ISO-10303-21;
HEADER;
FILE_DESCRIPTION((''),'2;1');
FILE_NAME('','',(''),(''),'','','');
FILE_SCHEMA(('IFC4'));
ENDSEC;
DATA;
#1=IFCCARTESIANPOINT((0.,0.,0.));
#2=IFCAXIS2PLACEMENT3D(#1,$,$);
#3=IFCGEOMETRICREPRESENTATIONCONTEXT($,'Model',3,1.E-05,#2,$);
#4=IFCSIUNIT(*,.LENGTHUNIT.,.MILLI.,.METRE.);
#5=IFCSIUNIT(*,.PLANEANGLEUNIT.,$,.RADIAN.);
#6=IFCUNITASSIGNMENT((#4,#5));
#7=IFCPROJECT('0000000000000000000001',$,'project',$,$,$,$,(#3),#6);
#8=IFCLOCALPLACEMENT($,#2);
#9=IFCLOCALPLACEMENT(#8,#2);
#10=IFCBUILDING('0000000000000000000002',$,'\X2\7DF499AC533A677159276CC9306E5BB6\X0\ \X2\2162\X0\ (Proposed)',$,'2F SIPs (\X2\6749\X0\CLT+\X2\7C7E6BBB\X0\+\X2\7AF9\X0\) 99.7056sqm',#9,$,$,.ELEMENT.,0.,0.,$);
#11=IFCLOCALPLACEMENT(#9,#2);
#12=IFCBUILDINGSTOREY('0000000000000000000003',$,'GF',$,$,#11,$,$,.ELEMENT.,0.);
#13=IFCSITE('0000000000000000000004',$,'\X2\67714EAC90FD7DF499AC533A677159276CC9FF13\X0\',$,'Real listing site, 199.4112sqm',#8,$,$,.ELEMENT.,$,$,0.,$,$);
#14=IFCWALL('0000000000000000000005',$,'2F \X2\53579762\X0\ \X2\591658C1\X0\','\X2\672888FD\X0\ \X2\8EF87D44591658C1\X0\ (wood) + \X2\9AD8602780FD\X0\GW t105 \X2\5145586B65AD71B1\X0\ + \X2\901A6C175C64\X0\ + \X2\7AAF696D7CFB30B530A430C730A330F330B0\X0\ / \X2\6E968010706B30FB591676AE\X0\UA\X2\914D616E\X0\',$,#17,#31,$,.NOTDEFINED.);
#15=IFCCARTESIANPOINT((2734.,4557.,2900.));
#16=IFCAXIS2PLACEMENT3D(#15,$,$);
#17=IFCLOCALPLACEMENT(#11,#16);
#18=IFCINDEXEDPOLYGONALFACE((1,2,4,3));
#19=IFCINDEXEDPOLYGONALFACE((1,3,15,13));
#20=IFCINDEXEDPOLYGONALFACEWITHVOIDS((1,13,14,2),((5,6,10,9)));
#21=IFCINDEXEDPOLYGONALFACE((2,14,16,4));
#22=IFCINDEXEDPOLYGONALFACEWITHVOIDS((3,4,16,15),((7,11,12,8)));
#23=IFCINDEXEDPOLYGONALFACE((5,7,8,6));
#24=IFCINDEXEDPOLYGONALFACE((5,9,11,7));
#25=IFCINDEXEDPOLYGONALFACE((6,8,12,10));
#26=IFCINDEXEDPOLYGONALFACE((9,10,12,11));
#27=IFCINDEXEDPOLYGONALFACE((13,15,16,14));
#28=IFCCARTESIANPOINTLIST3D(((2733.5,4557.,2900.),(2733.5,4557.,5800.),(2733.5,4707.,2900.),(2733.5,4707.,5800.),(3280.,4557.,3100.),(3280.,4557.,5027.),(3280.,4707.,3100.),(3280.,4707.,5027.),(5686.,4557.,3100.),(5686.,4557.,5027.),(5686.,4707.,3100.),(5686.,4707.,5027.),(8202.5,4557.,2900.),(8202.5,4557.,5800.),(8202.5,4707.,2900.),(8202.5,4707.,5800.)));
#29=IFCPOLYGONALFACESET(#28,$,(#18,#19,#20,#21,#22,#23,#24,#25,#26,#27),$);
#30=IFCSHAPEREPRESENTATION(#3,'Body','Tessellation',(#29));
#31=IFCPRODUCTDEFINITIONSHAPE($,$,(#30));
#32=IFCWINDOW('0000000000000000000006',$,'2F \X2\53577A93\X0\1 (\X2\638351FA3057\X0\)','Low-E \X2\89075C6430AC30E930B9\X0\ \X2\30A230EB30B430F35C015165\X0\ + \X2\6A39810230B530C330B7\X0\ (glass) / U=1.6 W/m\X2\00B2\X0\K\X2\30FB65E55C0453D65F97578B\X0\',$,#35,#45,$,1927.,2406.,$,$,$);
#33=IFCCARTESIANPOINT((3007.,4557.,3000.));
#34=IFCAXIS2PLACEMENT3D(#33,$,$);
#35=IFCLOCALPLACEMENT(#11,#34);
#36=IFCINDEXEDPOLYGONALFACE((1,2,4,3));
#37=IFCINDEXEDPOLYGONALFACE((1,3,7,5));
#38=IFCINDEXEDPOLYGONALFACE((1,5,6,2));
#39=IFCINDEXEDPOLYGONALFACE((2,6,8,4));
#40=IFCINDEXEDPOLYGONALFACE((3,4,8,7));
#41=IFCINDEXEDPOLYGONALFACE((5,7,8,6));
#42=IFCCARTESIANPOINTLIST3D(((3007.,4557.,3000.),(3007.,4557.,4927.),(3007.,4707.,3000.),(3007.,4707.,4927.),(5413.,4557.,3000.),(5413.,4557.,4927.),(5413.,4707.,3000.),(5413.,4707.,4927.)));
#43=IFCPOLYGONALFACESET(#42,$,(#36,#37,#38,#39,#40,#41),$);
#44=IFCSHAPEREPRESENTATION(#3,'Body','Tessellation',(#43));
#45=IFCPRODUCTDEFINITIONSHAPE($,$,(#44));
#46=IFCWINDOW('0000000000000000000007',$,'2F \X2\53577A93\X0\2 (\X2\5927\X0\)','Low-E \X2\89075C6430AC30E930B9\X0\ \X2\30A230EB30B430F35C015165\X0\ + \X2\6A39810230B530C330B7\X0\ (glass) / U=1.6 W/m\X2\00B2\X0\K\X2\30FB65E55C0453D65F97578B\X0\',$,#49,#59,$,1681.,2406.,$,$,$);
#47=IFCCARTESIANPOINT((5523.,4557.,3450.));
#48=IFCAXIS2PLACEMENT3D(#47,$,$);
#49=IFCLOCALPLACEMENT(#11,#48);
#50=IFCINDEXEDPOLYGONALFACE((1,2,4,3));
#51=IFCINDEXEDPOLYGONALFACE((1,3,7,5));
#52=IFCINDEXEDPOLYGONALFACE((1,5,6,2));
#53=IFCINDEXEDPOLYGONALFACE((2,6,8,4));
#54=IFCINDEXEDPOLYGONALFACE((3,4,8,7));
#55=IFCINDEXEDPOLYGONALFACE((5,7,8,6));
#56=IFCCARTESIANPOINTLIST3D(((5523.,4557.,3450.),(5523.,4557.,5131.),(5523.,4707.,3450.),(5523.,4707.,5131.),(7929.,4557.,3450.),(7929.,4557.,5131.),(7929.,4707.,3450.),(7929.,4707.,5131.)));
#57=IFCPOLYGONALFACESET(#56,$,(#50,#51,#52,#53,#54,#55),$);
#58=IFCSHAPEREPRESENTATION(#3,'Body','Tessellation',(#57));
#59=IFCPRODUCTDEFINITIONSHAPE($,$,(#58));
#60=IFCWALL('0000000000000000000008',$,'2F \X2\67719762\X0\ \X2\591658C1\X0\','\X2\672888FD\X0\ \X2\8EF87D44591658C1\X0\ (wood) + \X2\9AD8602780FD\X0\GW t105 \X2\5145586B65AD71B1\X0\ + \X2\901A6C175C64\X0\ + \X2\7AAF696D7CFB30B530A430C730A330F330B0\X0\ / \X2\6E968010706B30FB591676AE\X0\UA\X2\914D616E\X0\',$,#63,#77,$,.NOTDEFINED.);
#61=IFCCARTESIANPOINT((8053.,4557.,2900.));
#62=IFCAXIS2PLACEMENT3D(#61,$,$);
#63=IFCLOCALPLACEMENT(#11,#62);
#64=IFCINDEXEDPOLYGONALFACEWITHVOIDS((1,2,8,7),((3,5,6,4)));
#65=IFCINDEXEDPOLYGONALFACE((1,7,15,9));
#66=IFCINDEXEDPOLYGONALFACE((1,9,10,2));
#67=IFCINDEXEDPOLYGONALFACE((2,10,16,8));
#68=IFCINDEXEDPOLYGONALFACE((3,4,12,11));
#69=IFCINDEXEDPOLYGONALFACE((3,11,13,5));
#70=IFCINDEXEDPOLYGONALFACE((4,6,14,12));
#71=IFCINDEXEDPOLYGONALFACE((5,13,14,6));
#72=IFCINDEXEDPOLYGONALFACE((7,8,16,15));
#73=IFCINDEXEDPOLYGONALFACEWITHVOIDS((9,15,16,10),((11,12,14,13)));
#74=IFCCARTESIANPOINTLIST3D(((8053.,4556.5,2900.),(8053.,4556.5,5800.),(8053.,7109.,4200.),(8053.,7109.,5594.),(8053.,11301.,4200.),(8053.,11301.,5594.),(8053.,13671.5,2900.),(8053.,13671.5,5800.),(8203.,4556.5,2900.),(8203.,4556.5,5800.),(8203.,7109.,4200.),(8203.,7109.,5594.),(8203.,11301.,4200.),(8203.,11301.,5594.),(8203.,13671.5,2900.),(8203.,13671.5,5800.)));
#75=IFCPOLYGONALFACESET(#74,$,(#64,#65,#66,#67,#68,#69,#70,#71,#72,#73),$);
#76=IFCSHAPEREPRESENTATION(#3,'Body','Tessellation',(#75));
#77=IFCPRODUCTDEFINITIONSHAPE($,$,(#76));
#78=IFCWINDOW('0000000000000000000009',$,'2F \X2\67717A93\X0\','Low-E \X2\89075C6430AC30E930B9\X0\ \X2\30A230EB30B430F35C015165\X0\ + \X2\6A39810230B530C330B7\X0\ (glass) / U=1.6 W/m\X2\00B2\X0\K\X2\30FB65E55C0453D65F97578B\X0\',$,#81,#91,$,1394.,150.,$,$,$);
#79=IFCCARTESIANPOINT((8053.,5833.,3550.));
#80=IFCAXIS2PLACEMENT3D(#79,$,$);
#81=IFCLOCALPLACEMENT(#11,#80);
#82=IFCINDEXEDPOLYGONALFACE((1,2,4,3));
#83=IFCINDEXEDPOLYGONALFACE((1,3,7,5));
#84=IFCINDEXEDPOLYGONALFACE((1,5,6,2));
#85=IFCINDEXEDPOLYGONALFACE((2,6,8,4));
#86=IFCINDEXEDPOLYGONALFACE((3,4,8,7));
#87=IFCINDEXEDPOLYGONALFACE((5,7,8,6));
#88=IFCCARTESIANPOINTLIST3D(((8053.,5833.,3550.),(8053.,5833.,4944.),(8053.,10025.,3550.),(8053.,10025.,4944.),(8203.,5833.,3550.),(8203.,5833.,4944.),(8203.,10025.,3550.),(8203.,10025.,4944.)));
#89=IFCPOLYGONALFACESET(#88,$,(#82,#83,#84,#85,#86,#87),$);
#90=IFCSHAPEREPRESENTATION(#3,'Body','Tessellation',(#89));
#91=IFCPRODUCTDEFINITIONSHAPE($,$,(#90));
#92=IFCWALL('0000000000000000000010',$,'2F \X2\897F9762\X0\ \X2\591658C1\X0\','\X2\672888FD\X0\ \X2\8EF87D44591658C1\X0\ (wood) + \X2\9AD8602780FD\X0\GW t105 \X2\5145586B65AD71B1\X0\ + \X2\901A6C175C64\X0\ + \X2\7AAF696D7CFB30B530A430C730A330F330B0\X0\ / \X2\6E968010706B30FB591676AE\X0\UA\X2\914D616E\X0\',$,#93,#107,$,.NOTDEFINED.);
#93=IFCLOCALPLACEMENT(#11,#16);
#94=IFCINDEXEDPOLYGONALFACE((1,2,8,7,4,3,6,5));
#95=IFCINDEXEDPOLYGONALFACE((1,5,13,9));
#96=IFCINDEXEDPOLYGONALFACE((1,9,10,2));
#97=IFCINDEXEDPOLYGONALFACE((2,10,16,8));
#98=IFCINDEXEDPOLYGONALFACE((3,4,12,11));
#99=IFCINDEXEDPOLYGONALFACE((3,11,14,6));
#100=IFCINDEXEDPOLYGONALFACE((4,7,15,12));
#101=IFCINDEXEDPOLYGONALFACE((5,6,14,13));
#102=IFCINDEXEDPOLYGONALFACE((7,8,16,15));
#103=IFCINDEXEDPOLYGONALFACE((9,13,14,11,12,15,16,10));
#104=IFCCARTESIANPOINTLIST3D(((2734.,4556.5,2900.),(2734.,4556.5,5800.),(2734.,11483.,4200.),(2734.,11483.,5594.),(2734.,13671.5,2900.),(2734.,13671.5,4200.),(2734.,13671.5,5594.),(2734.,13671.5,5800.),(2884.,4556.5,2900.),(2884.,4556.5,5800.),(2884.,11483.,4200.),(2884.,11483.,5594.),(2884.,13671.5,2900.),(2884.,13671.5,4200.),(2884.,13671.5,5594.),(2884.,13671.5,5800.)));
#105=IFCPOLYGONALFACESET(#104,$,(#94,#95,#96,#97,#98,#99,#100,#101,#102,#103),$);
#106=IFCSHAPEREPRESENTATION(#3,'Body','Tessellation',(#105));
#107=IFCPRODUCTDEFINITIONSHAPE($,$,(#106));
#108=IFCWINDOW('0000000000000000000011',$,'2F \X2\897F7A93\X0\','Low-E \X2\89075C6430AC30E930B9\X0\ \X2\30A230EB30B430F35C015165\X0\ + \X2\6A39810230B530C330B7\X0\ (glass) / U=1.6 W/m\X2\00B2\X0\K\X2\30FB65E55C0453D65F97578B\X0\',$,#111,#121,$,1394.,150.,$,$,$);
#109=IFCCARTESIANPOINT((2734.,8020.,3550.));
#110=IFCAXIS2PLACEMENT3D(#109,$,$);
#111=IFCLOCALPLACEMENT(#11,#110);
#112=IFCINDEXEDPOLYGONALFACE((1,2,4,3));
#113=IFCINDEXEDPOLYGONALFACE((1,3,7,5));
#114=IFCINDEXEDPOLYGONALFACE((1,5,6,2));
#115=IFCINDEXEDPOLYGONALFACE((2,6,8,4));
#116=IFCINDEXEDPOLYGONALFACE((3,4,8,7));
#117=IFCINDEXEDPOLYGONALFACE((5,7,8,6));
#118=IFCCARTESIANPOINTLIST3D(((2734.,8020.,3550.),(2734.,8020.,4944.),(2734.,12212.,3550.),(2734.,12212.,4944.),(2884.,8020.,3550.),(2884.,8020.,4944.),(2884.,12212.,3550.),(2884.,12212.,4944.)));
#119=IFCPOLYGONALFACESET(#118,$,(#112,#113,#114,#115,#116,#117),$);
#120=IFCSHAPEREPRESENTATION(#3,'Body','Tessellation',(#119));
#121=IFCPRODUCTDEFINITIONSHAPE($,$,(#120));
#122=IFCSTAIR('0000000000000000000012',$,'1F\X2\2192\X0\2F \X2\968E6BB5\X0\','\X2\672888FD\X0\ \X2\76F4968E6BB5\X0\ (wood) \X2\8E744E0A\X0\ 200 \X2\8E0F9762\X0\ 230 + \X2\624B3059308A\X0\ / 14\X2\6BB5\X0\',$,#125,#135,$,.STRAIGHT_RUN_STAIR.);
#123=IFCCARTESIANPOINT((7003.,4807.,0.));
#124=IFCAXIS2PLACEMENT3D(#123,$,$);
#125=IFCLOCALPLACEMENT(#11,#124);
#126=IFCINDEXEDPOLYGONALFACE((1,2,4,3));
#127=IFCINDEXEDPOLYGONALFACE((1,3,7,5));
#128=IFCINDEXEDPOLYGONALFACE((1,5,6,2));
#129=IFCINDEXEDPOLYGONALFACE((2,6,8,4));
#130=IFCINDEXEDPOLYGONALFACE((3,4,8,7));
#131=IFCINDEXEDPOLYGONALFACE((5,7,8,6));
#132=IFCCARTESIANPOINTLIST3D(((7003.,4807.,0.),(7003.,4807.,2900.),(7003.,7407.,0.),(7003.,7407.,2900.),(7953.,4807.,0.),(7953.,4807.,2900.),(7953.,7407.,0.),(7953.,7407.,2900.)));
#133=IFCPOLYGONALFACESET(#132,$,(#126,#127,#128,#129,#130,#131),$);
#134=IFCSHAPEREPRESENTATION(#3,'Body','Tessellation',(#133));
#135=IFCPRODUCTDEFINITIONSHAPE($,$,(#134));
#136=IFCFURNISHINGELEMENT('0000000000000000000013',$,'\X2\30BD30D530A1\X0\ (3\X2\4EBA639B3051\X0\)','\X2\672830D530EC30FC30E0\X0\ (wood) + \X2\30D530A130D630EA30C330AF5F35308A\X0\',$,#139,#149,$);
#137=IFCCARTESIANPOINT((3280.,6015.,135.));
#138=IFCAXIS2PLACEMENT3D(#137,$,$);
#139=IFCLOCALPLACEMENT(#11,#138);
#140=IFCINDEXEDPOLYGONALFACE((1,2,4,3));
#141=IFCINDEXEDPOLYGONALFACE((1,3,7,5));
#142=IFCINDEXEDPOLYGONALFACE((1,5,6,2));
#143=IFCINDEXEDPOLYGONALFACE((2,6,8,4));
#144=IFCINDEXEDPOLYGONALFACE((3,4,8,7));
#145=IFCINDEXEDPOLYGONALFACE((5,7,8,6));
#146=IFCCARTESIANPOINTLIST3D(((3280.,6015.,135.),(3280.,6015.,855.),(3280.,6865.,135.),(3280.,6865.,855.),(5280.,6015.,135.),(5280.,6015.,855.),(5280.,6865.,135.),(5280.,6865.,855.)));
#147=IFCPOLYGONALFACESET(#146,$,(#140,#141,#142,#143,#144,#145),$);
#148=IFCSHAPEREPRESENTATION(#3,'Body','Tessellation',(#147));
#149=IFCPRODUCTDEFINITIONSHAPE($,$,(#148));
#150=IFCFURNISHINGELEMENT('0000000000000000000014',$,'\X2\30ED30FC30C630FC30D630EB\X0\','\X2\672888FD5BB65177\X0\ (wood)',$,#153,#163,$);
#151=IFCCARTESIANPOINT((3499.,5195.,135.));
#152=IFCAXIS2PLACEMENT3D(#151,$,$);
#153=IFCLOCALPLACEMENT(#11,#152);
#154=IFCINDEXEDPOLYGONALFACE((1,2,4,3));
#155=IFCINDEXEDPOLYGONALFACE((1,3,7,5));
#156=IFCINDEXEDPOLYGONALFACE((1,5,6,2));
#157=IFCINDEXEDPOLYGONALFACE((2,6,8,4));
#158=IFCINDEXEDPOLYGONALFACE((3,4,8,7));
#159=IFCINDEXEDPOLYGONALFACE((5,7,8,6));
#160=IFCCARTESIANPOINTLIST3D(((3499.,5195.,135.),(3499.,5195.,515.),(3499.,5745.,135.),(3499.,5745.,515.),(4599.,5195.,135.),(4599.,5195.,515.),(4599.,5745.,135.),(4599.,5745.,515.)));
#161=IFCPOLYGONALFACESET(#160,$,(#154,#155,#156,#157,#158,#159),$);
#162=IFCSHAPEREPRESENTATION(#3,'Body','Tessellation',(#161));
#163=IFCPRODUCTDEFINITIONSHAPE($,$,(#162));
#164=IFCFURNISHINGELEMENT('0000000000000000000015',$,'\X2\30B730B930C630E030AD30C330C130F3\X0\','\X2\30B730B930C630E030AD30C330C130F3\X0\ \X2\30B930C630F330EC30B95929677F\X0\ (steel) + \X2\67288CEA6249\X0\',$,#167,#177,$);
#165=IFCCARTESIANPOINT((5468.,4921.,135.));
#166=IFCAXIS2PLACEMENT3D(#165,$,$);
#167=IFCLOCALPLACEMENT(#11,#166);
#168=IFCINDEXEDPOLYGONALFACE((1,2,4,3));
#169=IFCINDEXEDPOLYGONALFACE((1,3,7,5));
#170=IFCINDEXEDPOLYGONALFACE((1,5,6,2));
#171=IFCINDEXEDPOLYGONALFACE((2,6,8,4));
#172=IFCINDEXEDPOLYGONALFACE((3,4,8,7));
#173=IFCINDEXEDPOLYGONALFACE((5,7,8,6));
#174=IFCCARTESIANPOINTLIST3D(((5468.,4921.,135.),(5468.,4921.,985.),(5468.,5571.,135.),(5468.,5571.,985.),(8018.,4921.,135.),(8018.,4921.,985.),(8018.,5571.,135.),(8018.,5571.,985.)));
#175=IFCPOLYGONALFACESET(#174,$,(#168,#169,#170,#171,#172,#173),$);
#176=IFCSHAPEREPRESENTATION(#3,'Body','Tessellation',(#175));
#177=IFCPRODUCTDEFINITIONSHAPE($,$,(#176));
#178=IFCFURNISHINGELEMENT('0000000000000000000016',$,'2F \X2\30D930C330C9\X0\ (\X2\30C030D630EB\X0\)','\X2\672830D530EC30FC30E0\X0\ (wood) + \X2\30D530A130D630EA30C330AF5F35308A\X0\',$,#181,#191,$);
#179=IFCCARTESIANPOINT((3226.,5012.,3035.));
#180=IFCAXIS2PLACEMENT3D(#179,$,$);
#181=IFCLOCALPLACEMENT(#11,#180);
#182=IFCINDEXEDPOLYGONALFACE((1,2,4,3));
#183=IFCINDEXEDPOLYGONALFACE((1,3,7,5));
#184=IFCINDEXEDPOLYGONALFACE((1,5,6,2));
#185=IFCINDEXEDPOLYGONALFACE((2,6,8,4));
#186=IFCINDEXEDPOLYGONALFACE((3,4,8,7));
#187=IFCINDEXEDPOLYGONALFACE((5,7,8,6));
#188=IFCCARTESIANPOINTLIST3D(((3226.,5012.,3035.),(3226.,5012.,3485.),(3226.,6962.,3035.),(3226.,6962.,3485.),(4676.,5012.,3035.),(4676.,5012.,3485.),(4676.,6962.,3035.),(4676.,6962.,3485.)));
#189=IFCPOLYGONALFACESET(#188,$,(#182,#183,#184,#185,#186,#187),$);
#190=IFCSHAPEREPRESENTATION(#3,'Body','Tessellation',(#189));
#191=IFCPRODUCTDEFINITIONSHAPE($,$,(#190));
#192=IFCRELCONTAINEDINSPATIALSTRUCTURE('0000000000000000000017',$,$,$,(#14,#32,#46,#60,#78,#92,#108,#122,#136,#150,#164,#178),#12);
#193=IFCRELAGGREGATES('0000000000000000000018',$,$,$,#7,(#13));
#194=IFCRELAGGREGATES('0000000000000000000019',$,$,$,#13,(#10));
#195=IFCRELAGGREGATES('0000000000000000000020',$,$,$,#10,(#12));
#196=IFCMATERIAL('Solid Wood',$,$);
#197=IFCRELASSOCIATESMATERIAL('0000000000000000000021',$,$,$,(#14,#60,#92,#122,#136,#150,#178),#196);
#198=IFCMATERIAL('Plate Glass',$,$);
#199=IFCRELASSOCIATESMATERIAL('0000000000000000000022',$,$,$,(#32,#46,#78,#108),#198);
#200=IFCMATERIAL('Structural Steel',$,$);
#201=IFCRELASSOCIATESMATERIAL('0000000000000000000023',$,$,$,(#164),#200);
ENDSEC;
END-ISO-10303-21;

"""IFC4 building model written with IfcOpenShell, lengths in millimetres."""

from ifc_helpers import new_model, si_unit, frame, frame_2d, origin, place, context, project, spatial, rectangle, extrude, material, element, fill, save


model = new_model("IFC4")

# Units and contexts
model_context = context("Model", 3, precision=1e-05, world=origin())
ifc_project = project(units=[si_unit("LENGTHUNIT", "METRE", prefix="MILLI"), si_unit("PLANEANGLEUNIT", "RADIAN")], contexts=[model_context])

# Site, building, storey
site_placement = place(None, origin())
site = spatial("IfcSite", under=ifc_project, at=site_placement, Name="東京都練馬区東大泉３", ObjectType="Real listing site, 199.4112sqm", CompositionType="ELEMENT", RefElevation=0.0)
building_placement = place(site_placement, origin())
building = spatial("IfcBuilding", under=site, at=building_placement, Name="練馬区東大泉の家 Ⅲ (Proposed)", ObjectType="2F SIPs (杉CLT+籾殻+竹) 99.7056sqm", CompositionType="ELEMENT", ElevationOfRefHeight=0.0, ElevationOfTerrain=0.0)
storey_placement = place(building_placement, origin())
storey = spatial("IfcBuildingStorey", under=building, at=storey_placement, Name="GF", CompositionType="ELEMENT", Elevation=0.0)

# Shared definitions
ifc_material_1 = material(Name="Solid Wood")

# Shared definitions
ifc_material_2 = material(Name="Plate Glass")

# Wall, openings, windows
wall_1_placement = place(storey_placement, frame((2734.0, 4557.0, 2900.0)))
wall_1 = element("IfcWall", 1, at=wall_1_placement, inside=storey, material=ifc_material_1, Name="2F 南面 外壁", Description="木製 軸組外壁 (wood) + 高性能GW t105 充填断熱 + 通気層 + 窯業系サイディング / 準耐火・外皮UA配慮", PredefinedType="NOTDEFINED", context=model_context, shape_type="SweptSolid", body=[
    extrude(rectangle(XDim=5469.0, YDim=150.0, at=frame_2d((2734.0, 75.0))), frame((2734.0, 4557.0, 2900.0)), (0.0, 0.0, 1.0), 2900.0),
])
opening_1_placement = place(storey_placement, frame((3007.0, 4557.0, 3000.0)))
opening_1 = element("IfcOpeningElement", 2, at=opening_1_placement, cuts=wall_1, PredefinedType="NOTDEFINED", context=model_context, shape_type="SweptSolid", body=[
    extrude(rectangle(XDim=2406.0, YDim=150.0, at=frame_2d((1203.0, 75.0))), frame((3007.0, 4557.0, 3000.0)), (0.0, 0.0, 1.0), 1927.0),
])
opening_2_placement = place(storey_placement, frame((5523.0, 4557.0, 3450.0)))
opening_2 = element("IfcOpeningElement", 3, at=opening_2_placement, cuts=wall_1, PredefinedType="NOTDEFINED", context=model_context, shape_type="SweptSolid", body=[
    extrude(rectangle(XDim=2406.0, YDim=150.0, at=frame_2d((1203.0, 75.0))), frame((5523.0, 4557.0, 3450.0)), (0.0, 0.0, 1.0), 1681.0),
])
window_1_placement = place(storey_placement, frame((3007.0, 4557.0, 3000.0)))
window_1 = element("IfcWindow", 4, at=window_1_placement, inside=storey, material=ifc_material_2, Name="2F 南窓1 (掃出し)", Description="Low-E 複層ガラス アルゴン封入 + 樹脂サッシ (glass) / U=1.6 W/m²K・日射取得型", OverallHeight=1927.0, OverallWidth=2406.0, context=model_context, shape_type="SweptSolid", body=[
    extrude(rectangle(XDim=2406.0, YDim=150.0, at=frame_2d((1203.0, 75.0))), frame((3007.0, 4557.0, 3000.0)), (0.0, 0.0, 1.0), 1927.0),
])
fill(opening_1, window_1)
window_2_placement = place(storey_placement, frame((5523.0, 4557.0, 3450.0)))
window_2 = element("IfcWindow", 5, at=window_2_placement, inside=storey, material=ifc_material_2, Name="2F 南窓2 (大)", Description="Low-E 複層ガラス アルゴン封入 + 樹脂サッシ (glass) / U=1.6 W/m²K・日射取得型", OverallHeight=1681.0, OverallWidth=2406.0, context=model_context, shape_type="SweptSolid", body=[
    extrude(rectangle(XDim=2406.0, YDim=150.0, at=frame_2d((1203.0, 75.0))), frame((5523.0, 4557.0, 3450.0)), (0.0, 0.0, 1.0), 1681.0),
])
fill(opening_2, window_2)

# Walls, openings, windows
wall_2_placement = place(storey_placement, frame((8053.0, 4557.0, 2900.0)))
wall_2 = element("IfcWall", 6, at=wall_2_placement, inside=storey, material=ifc_material_1, Name="2F 東面 外壁", Description="木製 軸組外壁 (wood) + 高性能GW t105 充填断熱 + 通気層 + 窯業系サイディング / 準耐火・外皮UA配慮", PredefinedType="NOTDEFINED", context=model_context, shape_type="SweptSolid", body=[
    extrude(rectangle(XDim=150.0, YDim=9115.0, at=frame_2d((75.0, 4557.0))), frame((8053.0, 4557.0, 2900.0)), (0.0, 0.0, 1.0), 2900.0),
])
opening_3_placement = place(storey_placement, frame((8053.0, 5833.0, 3550.0)))
opening_3 = element("IfcOpeningElement", 7, at=opening_3_placement, cuts=wall_2, PredefinedType="NOTDEFINED", context=model_context, shape_type="SweptSolid", body=[
    extrude(rectangle(XDim=150.0, YDim=4192.0, at=frame_2d((75.0, 2096.0))), frame((8053.0, 5833.0, 3550.0)), (0.0, 0.0, 1.0), 1394.0),
])
window_3_placement = place(storey_placement, frame((8053.0, 5833.0, 3550.0)))
window_3 = element("IfcWindow", 8, at=window_3_placement, inside=storey, material=ifc_material_2, Name="2F 東窓", Description="Low-E 複層ガラス アルゴン封入 + 樹脂サッシ (glass) / U=1.6 W/m²K・日射取得型", OverallHeight=1394.0, OverallWidth=150.0, context=model_context, shape_type="SweptSolid", body=[
    extrude(rectangle(XDim=150.0, YDim=4192.0, at=frame_2d((75.0, 2096.0))), frame((8053.0, 5833.0, 3550.0)), (0.0, 0.0, 1.0), 1394.0),
])
fill(opening_3, window_3)
wall_3_placement = place(storey_placement, frame((2734.0, 4557.0, 2900.0)))
wall_3 = element("IfcWall", 9, at=wall_3_placement, inside=storey, material=ifc_material_1, Name="2F 西面 外壁", Description="木製 軸組外壁 (wood) + 高性能GW t105 充填断熱 + 通気層 + 窯業系サイディング / 準耐火・外皮UA配慮", PredefinedType="NOTDEFINED", context=model_context, shape_type="SweptSolid", body=[
    extrude(rectangle(XDim=150.0, YDim=9115.0, at=frame_2d((75.0, 4557.0))), frame((2734.0, 4557.0, 2900.0)), (0.0, 0.0, 1.0), 2900.0),
])
opening_4_placement = place(storey_placement, frame((2734.0, 8020.0, 3550.0)))
opening_4 = element("IfcOpeningElement", 10, at=opening_4_placement, cuts=wall_3, PredefinedType="NOTDEFINED", context=model_context, shape_type="SweptSolid", body=[
    extrude(rectangle(XDim=150.0, YDim=4192.0, at=frame_2d((75.0, 2096.0))), frame((2734.0, 8020.0, 3550.0)), (0.0, 0.0, 1.0), 1394.0),
])
window_4_placement = place(storey_placement, frame((2734.0, 8020.0, 3550.0)))
window_4 = element("IfcWindow", 11, at=window_4_placement, inside=storey, material=ifc_material_2, Name="2F 西窓", Description="Low-E 複層ガラス アルゴン封入 + 樹脂サッシ (glass) / U=1.6 W/m²K・日射取得型", OverallHeight=1394.0, OverallWidth=150.0, context=model_context, shape_type="SweptSolid", body=[
    extrude(rectangle(XDim=150.0, YDim=4192.0, at=frame_2d((75.0, 2096.0))), frame((2734.0, 8020.0, 3550.0)), (0.0, 0.0, 1.0), 1394.0),
])
fill(opening_4, window_4)

# Stair
stair_placement = place(storey_placement, frame((7003.0, 4807.0, 0.0)))
element("IfcStair", 12, at=stair_placement, inside=storey, material=ifc_material_1, Name="1F→2F 階段", Description="木製 直階段 (wood) 蹴上 200 踏面 230 + 手すり / 14段", PredefinedType="STRAIGHT_RUN_STAIR", context=model_context, shape_type="SweptSolid", body=[
    extrude(rectangle(XDim=950.0, YDim=2600.0, at=frame_2d((475.0, 1300.0))), frame((7003.0, 4807.0, 0.0)), (0.0, 0.0, 1.0), 2900.0),
])

# Shared definitions
ifc_material_3 = material(Name="Structural Steel")

# Furnishing elements
furnishing_1_placement = place(storey_placement, frame((3280.0, 6015.0, 135.0)))
element("IfcFurnishingElement", 13, at=furnishing_1_placement, inside=storey, material=ifc_material_1, Name="ソファ (3人掛け)", Description="木フレーム (wood) + ファブリック張り", context=model_context, shape_type="SweptSolid", body=[
    extrude(rectangle(XDim=2000.0, YDim=850.0, at=frame_2d((1000.0, 425.0))), frame((3280.0, 6015.0, 135.0)), (0.0, 0.0, 1.0), 720.0),
])
furnishing_2_placement = place(storey_placement, frame((3499.0, 5195.0, 135.0)))
element("IfcFurnishingElement", 14, at=furnishing_2_placement, inside=storey, material=ifc_material_1, Name="ローテーブル", Description="木製家具 (wood)", context=model_context, shape_type="SweptSolid", body=[
    extrude(rectangle(XDim=1100.0, YDim=550.0, at=frame_2d((550.0, 275.0))), frame((3499.0, 5195.0, 135.0)), (0.0, 0.0, 1.0), 380.0),
])
furnishing_3_placement = place(storey_placement, frame((5468.0, 4921.0, 135.0)))
element("IfcFurnishingElement", 15, at=furnishing_3_placement, inside=storey, material=ifc_material_3, Name="システムキッチン", Description="システムキッチン ステンレス天板 (steel) + 木質扉", context=model_context, shape_type="SweptSolid", body=[
    extrude(rectangle(XDim=2550.0, YDim=650.0, at=frame_2d((1275.0, 325.0))), frame((5468.0, 4921.0, 135.0)), (0.0, 0.0, 1.0), 850.0),
])
furnishing_4_placement = place(storey_placement, frame((3226.0, 5012.0, 3035.0)))
element("IfcFurnishingElement", 16, at=furnishing_4_placement, inside=storey, material=ifc_material_1, Name="2F ベッド (ダブル)", Description="木フレーム (wood) + ファブリック張り", context=model_context, shape_type="SweptSolid", body=[
    extrude(rectangle(XDim=1450.0, YDim=1950.0, at=frame_2d((725.0, 975.0))), frame((3226.0, 5012.0, 3035.0)), (0.0, 0.0, 1.0), 450.0),
])

save(model, "model.ifc")
